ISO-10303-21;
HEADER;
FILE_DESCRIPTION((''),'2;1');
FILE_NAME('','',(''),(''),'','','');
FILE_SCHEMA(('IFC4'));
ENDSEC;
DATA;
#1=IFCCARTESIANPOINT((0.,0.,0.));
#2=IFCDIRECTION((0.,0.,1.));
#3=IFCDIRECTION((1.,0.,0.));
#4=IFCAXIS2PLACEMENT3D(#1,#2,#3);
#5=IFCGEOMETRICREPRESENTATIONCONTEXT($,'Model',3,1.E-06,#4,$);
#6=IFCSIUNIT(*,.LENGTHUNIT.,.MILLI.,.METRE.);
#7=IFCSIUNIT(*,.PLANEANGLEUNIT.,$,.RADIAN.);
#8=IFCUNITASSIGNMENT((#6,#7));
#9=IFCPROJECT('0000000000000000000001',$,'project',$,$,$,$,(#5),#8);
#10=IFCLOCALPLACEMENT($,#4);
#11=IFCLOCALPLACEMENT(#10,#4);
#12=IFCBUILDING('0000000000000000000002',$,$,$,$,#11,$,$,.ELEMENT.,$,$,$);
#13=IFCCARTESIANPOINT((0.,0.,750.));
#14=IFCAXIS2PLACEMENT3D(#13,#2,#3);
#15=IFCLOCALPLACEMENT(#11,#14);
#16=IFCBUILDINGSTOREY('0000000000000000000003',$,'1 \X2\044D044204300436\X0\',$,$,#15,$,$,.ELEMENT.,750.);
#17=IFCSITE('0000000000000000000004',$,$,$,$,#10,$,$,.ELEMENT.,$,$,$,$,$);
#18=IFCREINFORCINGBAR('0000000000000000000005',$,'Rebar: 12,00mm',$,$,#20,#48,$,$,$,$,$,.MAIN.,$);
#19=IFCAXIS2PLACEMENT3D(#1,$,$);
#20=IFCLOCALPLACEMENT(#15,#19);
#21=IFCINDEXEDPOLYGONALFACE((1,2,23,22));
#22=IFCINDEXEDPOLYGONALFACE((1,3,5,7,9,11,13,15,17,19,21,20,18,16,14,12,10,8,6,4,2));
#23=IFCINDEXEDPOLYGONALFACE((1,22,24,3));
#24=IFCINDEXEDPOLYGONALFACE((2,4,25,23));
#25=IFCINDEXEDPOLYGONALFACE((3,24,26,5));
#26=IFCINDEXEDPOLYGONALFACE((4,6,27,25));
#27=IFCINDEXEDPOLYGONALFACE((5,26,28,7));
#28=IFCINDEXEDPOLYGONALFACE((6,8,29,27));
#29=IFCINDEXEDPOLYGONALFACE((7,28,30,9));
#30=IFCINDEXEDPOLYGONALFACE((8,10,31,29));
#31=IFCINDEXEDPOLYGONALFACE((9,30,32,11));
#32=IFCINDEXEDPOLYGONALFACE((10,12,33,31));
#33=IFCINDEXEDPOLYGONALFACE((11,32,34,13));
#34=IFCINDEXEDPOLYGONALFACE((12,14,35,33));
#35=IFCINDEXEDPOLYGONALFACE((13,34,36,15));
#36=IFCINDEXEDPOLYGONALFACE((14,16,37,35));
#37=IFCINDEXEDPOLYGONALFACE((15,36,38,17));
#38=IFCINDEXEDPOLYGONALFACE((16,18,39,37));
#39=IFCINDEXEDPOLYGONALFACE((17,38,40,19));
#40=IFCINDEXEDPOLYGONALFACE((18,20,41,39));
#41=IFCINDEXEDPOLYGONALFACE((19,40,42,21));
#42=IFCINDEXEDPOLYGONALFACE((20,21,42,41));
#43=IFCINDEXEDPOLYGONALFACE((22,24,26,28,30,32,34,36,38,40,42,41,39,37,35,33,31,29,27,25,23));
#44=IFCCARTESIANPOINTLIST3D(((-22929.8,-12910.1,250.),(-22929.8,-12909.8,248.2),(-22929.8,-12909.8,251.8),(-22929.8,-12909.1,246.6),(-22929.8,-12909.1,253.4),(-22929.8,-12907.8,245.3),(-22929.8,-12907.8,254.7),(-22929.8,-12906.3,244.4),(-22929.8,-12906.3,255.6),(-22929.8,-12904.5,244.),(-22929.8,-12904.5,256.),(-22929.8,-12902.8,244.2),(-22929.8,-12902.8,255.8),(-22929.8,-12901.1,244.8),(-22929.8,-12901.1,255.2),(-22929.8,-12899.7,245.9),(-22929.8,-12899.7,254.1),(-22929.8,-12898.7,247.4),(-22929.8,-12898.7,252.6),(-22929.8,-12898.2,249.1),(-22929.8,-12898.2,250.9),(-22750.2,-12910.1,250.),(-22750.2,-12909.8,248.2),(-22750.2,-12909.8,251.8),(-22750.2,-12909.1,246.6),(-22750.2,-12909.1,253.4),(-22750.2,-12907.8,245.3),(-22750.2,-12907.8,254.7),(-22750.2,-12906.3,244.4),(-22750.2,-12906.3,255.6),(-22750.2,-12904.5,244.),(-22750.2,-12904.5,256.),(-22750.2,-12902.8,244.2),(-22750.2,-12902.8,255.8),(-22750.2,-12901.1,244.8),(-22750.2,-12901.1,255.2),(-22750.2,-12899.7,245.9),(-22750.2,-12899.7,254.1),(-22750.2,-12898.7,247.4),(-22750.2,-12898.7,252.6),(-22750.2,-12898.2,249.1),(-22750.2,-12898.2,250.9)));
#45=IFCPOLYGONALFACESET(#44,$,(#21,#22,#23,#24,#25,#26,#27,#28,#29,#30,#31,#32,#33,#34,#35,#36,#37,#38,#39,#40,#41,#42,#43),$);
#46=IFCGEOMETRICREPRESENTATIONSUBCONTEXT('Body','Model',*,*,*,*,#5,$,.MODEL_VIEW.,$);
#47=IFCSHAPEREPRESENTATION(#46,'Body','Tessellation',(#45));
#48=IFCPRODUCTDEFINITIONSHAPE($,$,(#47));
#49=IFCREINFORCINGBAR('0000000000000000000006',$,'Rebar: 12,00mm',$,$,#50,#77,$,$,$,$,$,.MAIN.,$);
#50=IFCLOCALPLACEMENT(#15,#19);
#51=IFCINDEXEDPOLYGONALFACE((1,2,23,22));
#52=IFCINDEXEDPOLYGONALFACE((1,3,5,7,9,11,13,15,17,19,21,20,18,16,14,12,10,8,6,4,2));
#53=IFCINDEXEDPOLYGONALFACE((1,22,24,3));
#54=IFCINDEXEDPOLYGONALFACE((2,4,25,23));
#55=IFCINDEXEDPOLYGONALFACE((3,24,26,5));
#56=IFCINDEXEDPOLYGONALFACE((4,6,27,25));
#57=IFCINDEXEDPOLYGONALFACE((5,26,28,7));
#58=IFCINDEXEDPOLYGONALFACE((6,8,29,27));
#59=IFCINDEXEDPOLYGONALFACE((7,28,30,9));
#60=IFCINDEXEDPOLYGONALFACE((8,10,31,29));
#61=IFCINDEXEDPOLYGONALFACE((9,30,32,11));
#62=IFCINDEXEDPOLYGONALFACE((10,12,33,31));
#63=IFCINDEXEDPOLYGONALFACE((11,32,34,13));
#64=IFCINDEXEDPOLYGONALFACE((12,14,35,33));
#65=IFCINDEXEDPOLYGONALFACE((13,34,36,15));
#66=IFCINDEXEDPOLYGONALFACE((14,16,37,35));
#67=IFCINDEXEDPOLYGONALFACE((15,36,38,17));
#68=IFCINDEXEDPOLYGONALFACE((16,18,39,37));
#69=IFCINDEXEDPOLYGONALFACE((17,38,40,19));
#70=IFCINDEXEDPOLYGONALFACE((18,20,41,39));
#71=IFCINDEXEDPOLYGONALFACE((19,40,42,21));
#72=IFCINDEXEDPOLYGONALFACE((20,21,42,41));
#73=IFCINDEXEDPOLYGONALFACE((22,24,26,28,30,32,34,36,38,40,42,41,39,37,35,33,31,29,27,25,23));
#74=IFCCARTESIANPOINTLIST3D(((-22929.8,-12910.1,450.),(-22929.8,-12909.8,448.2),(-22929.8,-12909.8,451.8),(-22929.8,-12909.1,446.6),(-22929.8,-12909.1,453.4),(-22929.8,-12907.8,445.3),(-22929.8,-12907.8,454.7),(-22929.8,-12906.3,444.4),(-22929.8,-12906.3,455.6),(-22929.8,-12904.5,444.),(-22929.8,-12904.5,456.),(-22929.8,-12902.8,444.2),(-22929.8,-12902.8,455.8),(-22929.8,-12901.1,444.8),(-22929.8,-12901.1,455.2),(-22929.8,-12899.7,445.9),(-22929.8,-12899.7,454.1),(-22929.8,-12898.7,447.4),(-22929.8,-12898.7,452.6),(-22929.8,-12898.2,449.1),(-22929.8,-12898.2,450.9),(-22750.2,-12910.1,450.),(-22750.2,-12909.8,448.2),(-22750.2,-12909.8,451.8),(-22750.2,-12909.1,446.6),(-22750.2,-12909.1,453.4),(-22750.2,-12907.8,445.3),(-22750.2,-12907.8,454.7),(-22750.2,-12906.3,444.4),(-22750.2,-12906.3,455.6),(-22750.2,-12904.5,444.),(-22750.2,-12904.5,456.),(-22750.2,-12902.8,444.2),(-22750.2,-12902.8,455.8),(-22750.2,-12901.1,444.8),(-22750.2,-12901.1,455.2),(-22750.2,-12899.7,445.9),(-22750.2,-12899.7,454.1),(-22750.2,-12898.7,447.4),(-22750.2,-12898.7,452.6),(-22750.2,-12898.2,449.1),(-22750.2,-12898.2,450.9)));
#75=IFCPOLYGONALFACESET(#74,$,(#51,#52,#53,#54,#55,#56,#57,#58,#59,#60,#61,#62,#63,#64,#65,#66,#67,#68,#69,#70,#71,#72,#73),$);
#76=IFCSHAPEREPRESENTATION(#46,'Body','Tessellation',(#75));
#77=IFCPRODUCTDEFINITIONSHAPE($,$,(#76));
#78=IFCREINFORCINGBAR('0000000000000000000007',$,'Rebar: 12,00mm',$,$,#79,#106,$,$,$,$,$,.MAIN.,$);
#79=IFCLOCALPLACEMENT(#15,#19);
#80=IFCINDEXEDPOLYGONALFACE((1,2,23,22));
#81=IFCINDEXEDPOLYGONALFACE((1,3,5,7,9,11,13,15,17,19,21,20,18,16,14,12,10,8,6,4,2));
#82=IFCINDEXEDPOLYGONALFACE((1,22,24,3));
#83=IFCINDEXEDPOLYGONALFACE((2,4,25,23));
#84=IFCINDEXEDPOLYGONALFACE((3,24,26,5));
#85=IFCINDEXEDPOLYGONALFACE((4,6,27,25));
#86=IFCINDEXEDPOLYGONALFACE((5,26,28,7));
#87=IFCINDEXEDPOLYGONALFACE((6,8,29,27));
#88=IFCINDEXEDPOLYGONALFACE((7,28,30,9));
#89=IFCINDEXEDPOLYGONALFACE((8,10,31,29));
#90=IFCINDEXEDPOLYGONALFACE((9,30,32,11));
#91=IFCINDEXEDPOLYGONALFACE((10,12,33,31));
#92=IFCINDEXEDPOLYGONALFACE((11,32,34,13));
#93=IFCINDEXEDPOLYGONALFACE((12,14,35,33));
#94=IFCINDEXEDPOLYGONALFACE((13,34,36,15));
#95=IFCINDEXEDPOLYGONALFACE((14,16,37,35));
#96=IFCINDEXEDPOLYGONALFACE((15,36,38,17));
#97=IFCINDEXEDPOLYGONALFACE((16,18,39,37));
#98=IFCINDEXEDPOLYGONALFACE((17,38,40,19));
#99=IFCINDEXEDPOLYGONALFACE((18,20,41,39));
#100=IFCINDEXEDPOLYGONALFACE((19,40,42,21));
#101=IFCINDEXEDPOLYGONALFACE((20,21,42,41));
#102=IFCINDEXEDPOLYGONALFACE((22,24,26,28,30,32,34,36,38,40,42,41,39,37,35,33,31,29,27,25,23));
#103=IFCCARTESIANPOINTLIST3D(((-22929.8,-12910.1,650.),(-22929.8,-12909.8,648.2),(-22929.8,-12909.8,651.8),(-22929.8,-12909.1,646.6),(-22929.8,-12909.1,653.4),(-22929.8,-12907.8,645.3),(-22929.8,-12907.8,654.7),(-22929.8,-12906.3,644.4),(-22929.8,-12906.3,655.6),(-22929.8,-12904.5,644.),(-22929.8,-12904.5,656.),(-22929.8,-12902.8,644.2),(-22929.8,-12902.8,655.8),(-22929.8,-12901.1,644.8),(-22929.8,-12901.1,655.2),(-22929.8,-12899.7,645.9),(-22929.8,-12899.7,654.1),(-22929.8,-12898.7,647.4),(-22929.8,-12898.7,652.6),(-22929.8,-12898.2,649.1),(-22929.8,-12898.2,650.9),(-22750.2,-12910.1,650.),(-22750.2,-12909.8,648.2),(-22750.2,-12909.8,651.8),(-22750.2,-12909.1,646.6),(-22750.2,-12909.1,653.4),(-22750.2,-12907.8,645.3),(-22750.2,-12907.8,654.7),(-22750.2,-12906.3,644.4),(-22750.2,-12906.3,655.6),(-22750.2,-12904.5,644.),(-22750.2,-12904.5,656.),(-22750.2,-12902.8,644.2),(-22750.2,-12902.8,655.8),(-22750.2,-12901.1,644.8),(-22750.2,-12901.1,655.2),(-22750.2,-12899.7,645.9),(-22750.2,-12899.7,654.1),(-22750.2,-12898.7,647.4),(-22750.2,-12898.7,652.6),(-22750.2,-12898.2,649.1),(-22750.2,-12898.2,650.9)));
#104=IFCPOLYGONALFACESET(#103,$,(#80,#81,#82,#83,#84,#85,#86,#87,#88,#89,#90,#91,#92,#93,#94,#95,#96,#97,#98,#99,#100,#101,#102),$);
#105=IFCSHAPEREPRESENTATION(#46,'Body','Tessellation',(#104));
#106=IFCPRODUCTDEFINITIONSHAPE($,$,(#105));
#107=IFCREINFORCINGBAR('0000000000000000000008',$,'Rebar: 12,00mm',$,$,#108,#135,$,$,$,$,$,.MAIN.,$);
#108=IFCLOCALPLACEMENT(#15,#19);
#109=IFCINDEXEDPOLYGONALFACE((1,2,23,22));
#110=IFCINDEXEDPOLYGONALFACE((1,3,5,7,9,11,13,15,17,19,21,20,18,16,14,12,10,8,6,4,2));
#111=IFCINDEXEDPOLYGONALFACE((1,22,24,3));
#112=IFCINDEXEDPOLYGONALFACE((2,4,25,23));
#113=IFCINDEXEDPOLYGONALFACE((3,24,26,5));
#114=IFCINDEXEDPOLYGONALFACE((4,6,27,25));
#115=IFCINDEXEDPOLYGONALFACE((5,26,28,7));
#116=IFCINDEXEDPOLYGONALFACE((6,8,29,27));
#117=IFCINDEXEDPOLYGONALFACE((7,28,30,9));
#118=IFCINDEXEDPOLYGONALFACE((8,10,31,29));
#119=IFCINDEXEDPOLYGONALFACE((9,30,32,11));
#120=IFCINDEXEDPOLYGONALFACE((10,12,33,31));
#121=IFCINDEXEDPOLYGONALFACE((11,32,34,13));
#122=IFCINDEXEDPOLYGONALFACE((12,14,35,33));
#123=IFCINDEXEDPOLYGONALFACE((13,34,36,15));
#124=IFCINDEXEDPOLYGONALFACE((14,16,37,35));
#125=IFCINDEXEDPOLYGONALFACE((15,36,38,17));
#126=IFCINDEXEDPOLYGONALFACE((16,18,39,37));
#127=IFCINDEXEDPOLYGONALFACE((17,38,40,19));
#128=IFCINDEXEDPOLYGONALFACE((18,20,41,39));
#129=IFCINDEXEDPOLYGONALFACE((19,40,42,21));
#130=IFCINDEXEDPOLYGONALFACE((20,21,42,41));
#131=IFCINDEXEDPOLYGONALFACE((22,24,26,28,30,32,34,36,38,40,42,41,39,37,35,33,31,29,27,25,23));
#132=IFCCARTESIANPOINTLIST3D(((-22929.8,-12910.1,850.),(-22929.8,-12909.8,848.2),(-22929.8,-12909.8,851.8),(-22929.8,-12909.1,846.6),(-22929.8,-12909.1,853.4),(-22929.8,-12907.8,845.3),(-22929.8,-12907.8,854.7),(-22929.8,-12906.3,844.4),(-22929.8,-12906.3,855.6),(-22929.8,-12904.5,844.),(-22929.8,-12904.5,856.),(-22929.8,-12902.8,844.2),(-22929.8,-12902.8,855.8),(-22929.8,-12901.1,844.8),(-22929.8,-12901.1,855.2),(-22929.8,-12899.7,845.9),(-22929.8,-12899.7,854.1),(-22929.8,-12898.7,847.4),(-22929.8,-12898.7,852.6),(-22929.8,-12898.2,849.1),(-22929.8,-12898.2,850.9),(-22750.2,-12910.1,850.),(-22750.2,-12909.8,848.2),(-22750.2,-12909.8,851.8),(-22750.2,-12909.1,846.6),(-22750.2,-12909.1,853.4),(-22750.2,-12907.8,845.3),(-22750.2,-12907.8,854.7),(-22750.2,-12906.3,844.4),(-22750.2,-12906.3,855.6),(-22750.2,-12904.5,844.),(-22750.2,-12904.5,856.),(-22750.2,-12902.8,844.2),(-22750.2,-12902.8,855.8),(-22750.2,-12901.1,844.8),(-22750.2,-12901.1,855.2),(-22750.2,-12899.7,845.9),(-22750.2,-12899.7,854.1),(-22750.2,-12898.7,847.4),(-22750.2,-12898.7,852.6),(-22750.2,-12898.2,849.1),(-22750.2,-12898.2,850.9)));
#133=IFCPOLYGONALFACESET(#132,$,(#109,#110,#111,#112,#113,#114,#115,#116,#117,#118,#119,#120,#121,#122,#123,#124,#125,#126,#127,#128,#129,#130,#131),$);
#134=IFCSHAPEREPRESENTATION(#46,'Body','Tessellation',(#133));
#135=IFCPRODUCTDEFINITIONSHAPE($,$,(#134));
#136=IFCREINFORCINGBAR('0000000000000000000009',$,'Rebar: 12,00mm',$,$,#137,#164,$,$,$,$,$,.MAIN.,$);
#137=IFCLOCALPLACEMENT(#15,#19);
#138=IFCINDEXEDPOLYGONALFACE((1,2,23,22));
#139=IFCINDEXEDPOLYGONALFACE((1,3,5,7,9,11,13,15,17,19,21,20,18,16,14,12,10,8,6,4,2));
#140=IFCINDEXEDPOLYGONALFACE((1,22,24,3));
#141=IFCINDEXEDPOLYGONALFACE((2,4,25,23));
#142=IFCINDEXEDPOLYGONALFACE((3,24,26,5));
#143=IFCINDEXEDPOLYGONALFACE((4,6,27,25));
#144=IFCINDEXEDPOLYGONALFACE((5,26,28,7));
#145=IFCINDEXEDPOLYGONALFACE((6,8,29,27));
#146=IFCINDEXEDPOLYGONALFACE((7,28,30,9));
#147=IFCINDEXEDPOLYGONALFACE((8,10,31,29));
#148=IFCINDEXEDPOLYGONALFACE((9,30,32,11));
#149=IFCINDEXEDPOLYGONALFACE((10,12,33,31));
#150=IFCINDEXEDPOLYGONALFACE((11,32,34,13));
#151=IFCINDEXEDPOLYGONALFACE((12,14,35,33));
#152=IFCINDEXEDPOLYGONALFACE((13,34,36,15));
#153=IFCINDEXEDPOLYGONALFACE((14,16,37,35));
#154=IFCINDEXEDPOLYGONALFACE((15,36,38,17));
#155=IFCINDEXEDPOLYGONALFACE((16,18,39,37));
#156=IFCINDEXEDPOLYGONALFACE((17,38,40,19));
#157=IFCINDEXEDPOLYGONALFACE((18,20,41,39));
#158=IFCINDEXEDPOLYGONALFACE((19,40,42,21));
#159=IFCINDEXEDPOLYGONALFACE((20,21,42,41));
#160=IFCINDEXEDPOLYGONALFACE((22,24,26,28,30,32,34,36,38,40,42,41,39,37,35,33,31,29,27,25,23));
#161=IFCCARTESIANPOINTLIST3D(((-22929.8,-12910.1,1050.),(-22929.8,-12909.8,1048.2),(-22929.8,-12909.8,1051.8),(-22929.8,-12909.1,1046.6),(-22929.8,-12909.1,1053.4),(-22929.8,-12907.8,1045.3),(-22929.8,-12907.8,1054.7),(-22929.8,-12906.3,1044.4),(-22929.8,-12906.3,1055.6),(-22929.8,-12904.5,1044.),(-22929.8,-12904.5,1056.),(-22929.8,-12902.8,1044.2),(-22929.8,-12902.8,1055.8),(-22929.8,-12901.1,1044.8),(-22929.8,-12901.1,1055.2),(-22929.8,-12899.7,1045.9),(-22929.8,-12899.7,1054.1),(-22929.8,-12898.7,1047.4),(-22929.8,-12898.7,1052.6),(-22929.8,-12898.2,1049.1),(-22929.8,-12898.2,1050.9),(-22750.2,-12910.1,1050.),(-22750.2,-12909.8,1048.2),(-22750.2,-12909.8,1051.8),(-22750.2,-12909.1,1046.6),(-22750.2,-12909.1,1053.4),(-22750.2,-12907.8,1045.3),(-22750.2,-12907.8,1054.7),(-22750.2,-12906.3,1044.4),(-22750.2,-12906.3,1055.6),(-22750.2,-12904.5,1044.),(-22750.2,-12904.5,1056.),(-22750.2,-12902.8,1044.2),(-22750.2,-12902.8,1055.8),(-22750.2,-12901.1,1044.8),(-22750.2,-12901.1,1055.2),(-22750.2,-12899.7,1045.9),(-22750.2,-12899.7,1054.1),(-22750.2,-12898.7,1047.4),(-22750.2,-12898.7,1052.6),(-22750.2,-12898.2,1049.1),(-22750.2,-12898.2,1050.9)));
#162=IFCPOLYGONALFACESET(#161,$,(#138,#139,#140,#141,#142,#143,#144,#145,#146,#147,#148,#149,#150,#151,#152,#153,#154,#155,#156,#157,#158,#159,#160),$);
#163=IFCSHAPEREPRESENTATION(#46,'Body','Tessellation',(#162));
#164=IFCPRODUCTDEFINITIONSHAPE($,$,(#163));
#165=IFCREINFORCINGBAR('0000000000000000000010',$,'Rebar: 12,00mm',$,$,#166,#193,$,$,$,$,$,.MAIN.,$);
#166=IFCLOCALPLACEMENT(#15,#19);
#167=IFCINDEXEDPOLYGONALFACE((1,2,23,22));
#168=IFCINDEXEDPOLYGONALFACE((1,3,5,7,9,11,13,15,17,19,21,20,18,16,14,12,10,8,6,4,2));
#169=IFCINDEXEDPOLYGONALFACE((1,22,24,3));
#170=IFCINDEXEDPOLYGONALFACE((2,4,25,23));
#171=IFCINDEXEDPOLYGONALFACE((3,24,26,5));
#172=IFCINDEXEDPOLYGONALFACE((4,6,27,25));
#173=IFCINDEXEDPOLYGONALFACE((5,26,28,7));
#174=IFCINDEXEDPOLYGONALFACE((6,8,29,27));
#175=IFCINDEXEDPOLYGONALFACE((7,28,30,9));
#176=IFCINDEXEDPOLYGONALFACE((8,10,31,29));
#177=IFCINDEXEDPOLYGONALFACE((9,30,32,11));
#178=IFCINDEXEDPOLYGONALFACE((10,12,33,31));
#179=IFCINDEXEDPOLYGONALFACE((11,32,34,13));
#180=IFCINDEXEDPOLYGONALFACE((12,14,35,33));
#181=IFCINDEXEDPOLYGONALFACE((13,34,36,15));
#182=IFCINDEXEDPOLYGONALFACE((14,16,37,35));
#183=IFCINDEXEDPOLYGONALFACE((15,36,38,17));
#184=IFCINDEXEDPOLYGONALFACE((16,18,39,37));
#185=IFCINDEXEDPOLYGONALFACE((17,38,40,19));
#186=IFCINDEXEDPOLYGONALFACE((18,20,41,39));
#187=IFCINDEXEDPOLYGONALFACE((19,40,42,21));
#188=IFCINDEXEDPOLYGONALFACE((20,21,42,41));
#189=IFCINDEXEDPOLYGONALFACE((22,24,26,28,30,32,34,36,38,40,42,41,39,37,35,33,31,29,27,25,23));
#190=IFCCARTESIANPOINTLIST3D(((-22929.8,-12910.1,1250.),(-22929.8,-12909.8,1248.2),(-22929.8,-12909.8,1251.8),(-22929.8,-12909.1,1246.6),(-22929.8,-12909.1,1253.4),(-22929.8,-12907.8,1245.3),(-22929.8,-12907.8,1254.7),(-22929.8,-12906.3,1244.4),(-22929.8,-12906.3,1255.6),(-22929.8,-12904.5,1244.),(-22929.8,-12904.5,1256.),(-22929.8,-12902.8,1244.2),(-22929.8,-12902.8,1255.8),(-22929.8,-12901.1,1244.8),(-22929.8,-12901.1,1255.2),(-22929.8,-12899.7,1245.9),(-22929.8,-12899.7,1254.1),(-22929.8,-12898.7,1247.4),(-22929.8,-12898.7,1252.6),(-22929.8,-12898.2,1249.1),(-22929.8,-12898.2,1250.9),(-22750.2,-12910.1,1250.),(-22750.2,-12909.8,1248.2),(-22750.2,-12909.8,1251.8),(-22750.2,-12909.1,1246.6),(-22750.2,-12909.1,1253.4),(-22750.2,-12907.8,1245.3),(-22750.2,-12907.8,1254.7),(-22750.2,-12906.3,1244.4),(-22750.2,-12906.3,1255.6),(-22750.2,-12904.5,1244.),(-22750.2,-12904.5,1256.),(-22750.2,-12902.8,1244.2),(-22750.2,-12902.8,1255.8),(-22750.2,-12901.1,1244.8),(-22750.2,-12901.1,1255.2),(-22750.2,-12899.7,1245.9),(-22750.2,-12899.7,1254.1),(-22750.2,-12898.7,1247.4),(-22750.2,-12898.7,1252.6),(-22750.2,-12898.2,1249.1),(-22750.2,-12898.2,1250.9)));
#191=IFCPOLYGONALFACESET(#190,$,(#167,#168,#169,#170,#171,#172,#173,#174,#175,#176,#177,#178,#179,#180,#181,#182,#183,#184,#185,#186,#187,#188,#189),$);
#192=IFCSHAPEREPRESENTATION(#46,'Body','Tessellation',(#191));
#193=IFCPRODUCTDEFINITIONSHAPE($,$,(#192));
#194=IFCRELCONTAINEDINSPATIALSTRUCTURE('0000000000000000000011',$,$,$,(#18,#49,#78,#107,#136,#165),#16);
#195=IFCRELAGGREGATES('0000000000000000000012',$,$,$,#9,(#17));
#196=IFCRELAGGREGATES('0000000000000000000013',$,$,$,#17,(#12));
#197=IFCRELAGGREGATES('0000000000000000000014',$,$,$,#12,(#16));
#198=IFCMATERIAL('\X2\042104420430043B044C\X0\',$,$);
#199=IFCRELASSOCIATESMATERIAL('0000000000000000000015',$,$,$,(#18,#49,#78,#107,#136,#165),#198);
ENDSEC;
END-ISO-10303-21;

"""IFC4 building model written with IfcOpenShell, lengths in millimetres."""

from ifc_helpers import new_model, entity, si_unit, frame, origin_with_axes, place, context, subcontext, project, spatial, source, transform, mapped, material, element, save


model = new_model("IFC4")

# Units and contexts
model_context = context("Model", 3, precision=1e-06, world=origin_with_axes())
body_context = subcontext(model_context, "Body", "Model", "MODEL_VIEW")
ifc_project = project(units=[si_unit("LENGTHUNIT", "METRE", prefix="MILLI"), si_unit("PLANEANGLEUNIT", "RADIAN")], contexts=[model_context])

# Site, building, storey
site_placement = place(None, origin_with_axes())
site = spatial("IfcSite", under=ifc_project, at=site_placement, CompositionType="ELEMENT")
building_placement = place(site_placement, origin_with_axes())
building = spatial("IfcBuilding", under=site, at=building_placement, CompositionType="ELEMENT")
storey_placement = place(building_placement, frame((0.0, 0.0, 750.0), z_axis=(0.0, 0.0, 1.0), x_axis=(1.0, 0.0, 0.0)))
storey = spatial("IfcBuildingStorey", under=building, at=storey_placement, Name="1 этаж", CompositionType="ELEMENT", Elevation=750.0)

# Reinforcing bars
ifc_material = material(Name="Сталь")
shared_shape_1 = source(origin_with_axes(), body_context, "Body", "AdvancedSweptSolid", [
    entity("IfcSweptDiskSolid", entity("IfcIndexedPolyCurve", entity("IfcCartesianPointList3D", [[0.0, 0.0, 0.0], [179.7, 0.0, 0.0]]), [entity("IfcLineIndex", [1, 2])]), 6.0),
])
reinforcing_bar_1_placement = place(storey_placement, origin_with_axes())
element("IfcReinforcingBar", 1, at=reinforcing_bar_1_placement, inside=storey, material=ifc_material, Name="Rebar: 12,00mm", PredefinedType="MAIN", context=body_context, shape_type="MappedRepresentation", body=[
    mapped(shared_shape_1, transform((-22750.2, -12904.1, 250.0), x_axis=(-1.0, 0.0, 0.0), y_axis=(0.0, -1.0, 0.0), z_axis=(0.0, 0.0, 1.0), scale=1.0)),
])
reinforcing_bar_2_placement = place(storey_placement, origin_with_axes())
element("IfcReinforcingBar", 2, at=reinforcing_bar_2_placement, inside=storey, material=ifc_material, Name="Rebar: 12,00mm", PredefinedType="MAIN", context=body_context, shape_type="MappedRepresentation", body=[
    mapped(shared_shape_1, transform((-22750.2, -12904.1, 450.0), x_axis=(-1.0, 0.0, 0.0), y_axis=(0.0, -1.0, 0.0), z_axis=(0.0, 0.0, 1.0), scale=1.0)),
])
reinforcing_bar_3_placement = place(storey_placement, origin_with_axes())
element("IfcReinforcingBar", 3, at=reinforcing_bar_3_placement, inside=storey, material=ifc_material, Name="Rebar: 12,00mm", PredefinedType="MAIN", context=body_context, shape_type="MappedRepresentation", body=[
    mapped(shared_shape_1, transform((-22750.2, -12904.1, 650.0), x_axis=(-1.0, 0.0, 0.0), y_axis=(0.0, -1.0, 0.0), z_axis=(0.0, 0.0, 1.0), scale=1.0)),
])
reinforcing_bar_4_placement = place(storey_placement, origin_with_axes())
element("IfcReinforcingBar", 4, at=reinforcing_bar_4_placement, inside=storey, material=ifc_material, Name="Rebar: 12,00mm", PredefinedType="MAIN", context=body_context, shape_type="MappedRepresentation", body=[
    mapped(shared_shape_1, transform((-22750.2, -12904.1, 850.0), x_axis=(-1.0, 0.0, 0.0), y_axis=(0.0, -1.0, 0.0), z_axis=(0.0, 0.0, 1.0), scale=1.0)),
])
reinforcing_bar_5_placement = place(storey_placement, origin_with_axes())
element("IfcReinforcingBar", 5, at=reinforcing_bar_5_placement, inside=storey, material=ifc_material, Name="Rebar: 12,00mm", PredefinedType="MAIN", context=body_context, shape_type="MappedRepresentation", body=[
    mapped(shared_shape_1, transform((-22750.2, -12904.1, 1050.0), x_axis=(-1.0, 0.0, 0.0), y_axis=(0.0, -1.0, 0.0), z_axis=(0.0, 0.0, 1.0), scale=1.0)),
])
reinforcing_bar_6_placement = place(storey_placement, origin_with_axes())
element("IfcReinforcingBar", 6, at=reinforcing_bar_6_placement, inside=storey, material=ifc_material, Name="Rebar: 12,00mm", PredefinedType="MAIN", context=body_context, shape_type="MappedRepresentation", body=[
    mapped(shared_shape_1, transform((-22750.2, -12904.1, 1250.0), x_axis=(-1.0, 0.0, 0.0), y_axis=(0.0, -1.0, 0.0), z_axis=(0.0, 0.0, 1.0), scale=1.0)),
])

save(model, "model.ifc")
